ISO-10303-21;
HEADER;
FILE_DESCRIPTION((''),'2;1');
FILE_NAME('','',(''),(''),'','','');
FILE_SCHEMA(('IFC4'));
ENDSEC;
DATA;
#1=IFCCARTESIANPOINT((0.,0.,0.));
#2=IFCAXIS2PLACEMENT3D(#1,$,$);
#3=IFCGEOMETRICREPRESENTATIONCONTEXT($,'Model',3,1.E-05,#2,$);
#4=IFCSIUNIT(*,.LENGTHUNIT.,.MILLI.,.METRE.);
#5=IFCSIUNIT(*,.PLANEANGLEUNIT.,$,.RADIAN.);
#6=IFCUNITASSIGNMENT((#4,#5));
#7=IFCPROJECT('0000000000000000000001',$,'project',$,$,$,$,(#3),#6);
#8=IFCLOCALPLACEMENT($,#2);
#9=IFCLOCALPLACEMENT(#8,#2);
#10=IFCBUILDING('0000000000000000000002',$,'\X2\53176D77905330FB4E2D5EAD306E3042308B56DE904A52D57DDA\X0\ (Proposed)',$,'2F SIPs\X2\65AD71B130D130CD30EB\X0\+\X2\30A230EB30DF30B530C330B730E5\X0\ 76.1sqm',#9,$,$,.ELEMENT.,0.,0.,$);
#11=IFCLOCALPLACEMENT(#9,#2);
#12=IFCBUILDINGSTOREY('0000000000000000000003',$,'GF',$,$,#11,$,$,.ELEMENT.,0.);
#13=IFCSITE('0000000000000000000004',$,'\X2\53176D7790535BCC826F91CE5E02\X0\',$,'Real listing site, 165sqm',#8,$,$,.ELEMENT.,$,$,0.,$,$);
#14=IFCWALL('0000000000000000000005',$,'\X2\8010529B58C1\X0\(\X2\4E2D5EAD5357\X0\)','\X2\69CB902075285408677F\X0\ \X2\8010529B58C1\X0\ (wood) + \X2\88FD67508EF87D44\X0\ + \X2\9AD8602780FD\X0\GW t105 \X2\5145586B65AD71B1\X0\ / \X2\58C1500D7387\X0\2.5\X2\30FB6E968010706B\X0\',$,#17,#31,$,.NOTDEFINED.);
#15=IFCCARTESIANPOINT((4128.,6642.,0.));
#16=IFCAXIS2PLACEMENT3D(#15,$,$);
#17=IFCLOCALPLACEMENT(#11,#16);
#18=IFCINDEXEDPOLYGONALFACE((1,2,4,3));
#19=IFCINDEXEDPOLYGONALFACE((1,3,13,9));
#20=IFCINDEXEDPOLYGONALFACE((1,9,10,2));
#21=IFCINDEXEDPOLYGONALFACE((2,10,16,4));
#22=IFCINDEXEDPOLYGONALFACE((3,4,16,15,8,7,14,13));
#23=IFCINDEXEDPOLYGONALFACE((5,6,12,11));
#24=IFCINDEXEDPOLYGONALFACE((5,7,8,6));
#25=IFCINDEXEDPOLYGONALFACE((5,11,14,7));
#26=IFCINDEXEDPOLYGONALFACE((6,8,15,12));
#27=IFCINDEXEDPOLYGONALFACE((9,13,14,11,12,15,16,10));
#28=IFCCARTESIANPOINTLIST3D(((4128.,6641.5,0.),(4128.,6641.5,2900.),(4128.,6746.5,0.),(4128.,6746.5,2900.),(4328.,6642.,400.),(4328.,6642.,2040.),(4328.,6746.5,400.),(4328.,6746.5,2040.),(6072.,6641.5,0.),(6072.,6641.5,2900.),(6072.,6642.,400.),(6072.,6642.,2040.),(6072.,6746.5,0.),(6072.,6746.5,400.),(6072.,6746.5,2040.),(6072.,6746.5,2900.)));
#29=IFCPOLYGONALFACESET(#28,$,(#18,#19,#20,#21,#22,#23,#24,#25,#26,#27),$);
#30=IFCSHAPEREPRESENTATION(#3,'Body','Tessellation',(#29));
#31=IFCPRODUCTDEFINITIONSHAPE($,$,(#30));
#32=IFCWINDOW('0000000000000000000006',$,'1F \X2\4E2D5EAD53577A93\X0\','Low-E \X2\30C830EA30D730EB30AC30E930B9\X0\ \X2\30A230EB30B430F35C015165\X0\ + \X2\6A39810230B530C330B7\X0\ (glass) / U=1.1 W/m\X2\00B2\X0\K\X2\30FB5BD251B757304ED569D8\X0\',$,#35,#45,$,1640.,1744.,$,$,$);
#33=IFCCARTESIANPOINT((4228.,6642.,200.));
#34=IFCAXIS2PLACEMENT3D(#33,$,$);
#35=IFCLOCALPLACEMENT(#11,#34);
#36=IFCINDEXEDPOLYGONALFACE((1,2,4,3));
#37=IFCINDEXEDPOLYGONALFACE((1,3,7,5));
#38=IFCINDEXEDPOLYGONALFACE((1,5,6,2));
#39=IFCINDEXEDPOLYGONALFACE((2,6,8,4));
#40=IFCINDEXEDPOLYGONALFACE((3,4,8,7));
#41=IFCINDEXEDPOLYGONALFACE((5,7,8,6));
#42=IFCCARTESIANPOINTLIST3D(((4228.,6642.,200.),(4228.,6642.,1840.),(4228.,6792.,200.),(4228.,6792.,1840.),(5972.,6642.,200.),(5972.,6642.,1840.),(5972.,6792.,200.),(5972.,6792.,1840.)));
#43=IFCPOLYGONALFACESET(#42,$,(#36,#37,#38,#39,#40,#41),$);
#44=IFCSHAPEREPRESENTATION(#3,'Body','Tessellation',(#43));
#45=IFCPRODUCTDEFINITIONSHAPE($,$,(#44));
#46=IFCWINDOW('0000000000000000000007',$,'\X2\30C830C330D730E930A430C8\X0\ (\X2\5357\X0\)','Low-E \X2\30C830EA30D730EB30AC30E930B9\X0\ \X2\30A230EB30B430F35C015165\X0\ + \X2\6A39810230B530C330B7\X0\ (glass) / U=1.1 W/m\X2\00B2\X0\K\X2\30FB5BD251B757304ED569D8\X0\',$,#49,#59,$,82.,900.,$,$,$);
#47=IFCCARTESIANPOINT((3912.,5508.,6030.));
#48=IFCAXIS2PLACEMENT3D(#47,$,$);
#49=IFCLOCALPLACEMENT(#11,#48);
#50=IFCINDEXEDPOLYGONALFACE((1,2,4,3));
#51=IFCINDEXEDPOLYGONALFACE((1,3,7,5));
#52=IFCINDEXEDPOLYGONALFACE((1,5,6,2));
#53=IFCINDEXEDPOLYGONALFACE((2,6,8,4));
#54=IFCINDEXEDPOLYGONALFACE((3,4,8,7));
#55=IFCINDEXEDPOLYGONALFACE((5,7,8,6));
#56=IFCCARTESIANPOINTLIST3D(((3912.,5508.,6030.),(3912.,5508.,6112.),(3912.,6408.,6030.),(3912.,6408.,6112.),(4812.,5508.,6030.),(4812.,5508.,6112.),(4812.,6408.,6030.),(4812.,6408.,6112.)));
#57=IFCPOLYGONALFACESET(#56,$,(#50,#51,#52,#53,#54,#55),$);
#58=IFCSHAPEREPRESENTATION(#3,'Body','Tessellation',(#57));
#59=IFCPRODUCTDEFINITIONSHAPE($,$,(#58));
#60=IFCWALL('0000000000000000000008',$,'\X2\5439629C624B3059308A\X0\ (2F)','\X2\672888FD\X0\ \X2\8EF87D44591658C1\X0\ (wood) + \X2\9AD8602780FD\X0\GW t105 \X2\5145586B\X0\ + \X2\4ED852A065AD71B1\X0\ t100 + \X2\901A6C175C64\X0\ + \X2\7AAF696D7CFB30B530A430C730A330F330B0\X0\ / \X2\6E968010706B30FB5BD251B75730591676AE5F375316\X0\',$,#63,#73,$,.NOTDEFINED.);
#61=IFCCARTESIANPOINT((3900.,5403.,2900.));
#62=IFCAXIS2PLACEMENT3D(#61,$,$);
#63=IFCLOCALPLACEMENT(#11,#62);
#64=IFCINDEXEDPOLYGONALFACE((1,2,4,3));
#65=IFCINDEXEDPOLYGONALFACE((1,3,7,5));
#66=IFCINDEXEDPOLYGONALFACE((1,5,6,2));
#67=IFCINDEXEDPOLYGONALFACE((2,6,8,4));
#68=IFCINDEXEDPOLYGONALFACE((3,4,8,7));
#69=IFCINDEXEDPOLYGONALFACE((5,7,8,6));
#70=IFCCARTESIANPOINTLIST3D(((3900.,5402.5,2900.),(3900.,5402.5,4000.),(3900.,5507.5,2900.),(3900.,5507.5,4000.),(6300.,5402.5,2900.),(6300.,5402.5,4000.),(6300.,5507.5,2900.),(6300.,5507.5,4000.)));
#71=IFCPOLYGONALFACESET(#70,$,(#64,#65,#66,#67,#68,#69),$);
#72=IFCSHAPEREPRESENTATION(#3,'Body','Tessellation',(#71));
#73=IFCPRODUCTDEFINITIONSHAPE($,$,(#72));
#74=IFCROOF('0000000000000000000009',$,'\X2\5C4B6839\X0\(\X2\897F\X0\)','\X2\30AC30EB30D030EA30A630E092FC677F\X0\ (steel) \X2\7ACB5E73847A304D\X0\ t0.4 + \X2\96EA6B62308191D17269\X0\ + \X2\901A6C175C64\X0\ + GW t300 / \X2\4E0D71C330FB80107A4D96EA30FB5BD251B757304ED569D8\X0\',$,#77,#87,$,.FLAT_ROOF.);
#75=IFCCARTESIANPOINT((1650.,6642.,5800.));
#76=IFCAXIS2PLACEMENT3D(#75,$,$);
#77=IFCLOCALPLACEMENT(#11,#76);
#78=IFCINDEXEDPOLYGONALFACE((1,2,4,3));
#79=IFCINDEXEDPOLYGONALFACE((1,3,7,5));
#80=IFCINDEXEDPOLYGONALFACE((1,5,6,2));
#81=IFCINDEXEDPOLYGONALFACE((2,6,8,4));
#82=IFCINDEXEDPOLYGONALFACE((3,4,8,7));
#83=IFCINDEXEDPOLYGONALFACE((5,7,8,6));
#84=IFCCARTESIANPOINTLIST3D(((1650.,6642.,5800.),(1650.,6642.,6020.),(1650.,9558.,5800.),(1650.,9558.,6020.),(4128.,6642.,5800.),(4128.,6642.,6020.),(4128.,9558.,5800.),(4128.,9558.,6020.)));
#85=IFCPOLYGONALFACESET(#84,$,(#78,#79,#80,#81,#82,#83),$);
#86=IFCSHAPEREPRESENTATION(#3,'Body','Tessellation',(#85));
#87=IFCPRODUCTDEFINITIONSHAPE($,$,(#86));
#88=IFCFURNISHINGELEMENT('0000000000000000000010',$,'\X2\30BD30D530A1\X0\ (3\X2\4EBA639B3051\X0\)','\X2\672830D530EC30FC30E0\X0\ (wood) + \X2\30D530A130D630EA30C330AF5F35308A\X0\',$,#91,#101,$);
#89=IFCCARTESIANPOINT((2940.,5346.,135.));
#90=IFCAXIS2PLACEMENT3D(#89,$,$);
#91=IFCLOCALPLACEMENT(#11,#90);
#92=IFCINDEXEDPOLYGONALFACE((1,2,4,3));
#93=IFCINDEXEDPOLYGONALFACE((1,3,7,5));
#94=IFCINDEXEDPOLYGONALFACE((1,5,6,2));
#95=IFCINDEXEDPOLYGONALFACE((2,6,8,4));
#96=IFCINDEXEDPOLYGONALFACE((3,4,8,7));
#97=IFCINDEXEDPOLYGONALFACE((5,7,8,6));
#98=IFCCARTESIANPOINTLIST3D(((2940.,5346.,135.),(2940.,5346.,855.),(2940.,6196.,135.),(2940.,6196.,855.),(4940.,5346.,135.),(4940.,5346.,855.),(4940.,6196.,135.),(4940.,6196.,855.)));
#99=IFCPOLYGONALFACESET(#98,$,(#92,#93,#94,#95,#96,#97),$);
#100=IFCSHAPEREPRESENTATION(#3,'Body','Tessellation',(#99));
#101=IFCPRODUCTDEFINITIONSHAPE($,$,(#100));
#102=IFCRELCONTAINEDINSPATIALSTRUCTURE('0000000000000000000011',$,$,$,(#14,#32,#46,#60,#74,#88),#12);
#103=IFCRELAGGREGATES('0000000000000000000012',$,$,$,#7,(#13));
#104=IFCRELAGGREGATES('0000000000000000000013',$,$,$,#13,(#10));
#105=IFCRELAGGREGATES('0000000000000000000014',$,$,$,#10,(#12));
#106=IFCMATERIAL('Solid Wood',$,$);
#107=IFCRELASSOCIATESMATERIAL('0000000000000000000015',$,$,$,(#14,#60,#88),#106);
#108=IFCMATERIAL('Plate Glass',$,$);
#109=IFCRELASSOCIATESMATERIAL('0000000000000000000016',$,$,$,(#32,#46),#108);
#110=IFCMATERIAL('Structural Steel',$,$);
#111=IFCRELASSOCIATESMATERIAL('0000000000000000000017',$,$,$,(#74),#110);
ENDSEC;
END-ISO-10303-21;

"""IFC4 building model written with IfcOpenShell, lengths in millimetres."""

from ifc_helpers import new_model, si_unit, frame, frame_2d, origin, place, context, project, spatial, rectangle, extrude, material, element, fill, save


model = new_model("IFC4")

# Units and contexts
model_context = context("Model", 3, precision=1e-05, world=origin())
ifc_project = project(units=[si_unit("LENGTHUNIT", "METRE", prefix="MILLI"), si_unit("PLANEANGLEUNIT", "RADIAN")], contexts=[model_context])

# Site, building, storey
site_placement = place(None, origin())
site = spatial("IfcSite", under=ifc_project, at=site_placement, Name="北海道富良野市", ObjectType="Real listing site, 165sqm", CompositionType="ELEMENT", RefElevation=0.0)
building_placement = place(site_placement, origin())
building = spatial("IfcBuilding", under=site, at=building_placement, Name="北海道・中庭のある回遊動線 (Proposed)", ObjectType="2F SIPs断熱パネル+アルミサッシュ 76.1sqm", CompositionType="ELEMENT", ElevationOfRefHeight=0.0, ElevationOfTerrain=0.0)
storey_placement = place(building_placement, origin())
storey = spatial("IfcBuildingStorey", under=building, at=storey_placement, Name="GF", CompositionType="ELEMENT", Elevation=0.0)

# Shared definitions
ifc_material_1 = material(Name="Solid Wood")

# Wall, opening, window
wall_1_placement = place(storey_placement, frame((4128.0, 6642.0, 0.0)))
wall_1 = element("IfcWall", 1, at=wall_1_placement, inside=storey, material=ifc_material_1, Name="耐力壁(中庭南)", Description="構造用合板 耐力壁 (wood) + 製材軸組 + 高性能GW t105 充填断熱 / 壁倍率2.5・準耐火", PredefinedType="NOTDEFINED", context=model_context, shape_type="SweptSolid", body=[
    extrude(rectangle(XDim=1944.0, YDim=105.0, at=frame_2d((972.0, 52.0))), frame((4128.0, 6642.0, 0.0)), (0.0, 0.0, 1.0), 2900.0),
])
opening_placement = place(storey_placement, frame((4228.0, 6642.0, 200.0)))
opening = element("IfcOpeningElement", 2, at=opening_placement, cuts=wall_1, PredefinedType="NOTDEFINED", context=model_context, shape_type="SweptSolid", body=[
    extrude(rectangle(XDim=1744.0, YDim=150.0, at=frame_2d((872.0, 75.0))), frame((4228.0, 6642.0, 200.0)), (0.0, 0.0, 1.0), 1640.0),
])
ifc_material_2 = material(Name="Plate Glass")
window_1_placement = place(storey_placement, frame((4228.0, 6642.0, 200.0)))
window_1 = element("IfcWindow", 3, at=window_1_placement, inside=storey, material=ifc_material_2, Name="1F 中庭南窓", Description="Low-E トリプルガラス アルゴン封入 + 樹脂サッシ (glass) / U=1.1 W/m²K・寒冷地仕様", OverallHeight=1640.0, OverallWidth=1744.0, context=model_context, shape_type="SweptSolid", body=[
    extrude(rectangle(XDim=1744.0, YDim=150.0, at=frame_2d((872.0, 75.0))), frame((4228.0, 6642.0, 200.0)), (0.0, 0.0, 1.0), 1640.0),
])
fill(opening, window_1)

# Window
window_2_placement = place(storey_placement, frame((3912.0, 5508.0, 6030.0)))
element("IfcWindow", 4, at=window_2_placement, inside=storey, material=ifc_material_2, Name="トップライト (南)", Description="Low-E トリプルガラス アルゴン封入 + 樹脂サッシ (glass) / U=1.1 W/m²K・寒冷地仕様", OverallHeight=82.0, OverallWidth=900.0, context=model_context, shape_type="SweptSolid", body=[
    extrude(rectangle(XDim=900.0, YDim=900.0, at=frame_2d((450.0, 450.0))), frame((3912.0, 5508.0, 6030.0)), (0.0, 0.0, 1.0), 82.0),
])

# Wall
wall_2_placement = place(storey_placement, frame((3900.0, 5403.0, 2900.0)))
element("IfcWall", 5, at=wall_2_placement, inside=storey, material=ifc_material_1, Name="吹抜手すり (2F)", Description="木製 軸組外壁 (wood) + 高性能GW t105 充填 + 付加断熱 t100 + 通気層 + 窯業系サイディング / 準耐火・寒冷地外皮強化", PredefinedType="NOTDEFINED", context=model_context, shape_type="SweptSolid", body=[
    extrude(rectangle(XDim=2400.0, YDim=105.0, at=frame_2d((1200.0, 52.0))), frame((3900.0, 5403.0, 2900.0)), (0.0, 0.0, 1.0), 1100.0),
])

# Roof
ifc_material_3 = material(Name="Structural Steel")
for number, where, name in (
    (6, (1650.0, 6642.0, 5800.0), "屋根(西)"),
):
    element("IfcRoof", number, at=place(storey_placement, frame(where)), inside=storey, material=ifc_material_3, Name=name, Description="ガルバリウム鋼板 (steel) 立平葺き t0.4 + 雪止め金物 + 通気層 + GW t300 / 不燃・耐積雪・寒冷地仕様", PredefinedType="FLAT_ROOF", context=model_context, shape_type="SweptSolid", body=[
        extrude(rectangle(XDim=2478.0, YDim=2916.0, at=frame_2d((1239.0, 1458.0))), frame((1650.0, 6642.0, 5800.0)), (0.0, 0.0, 1.0), 220.0),
    ])

# Furnishing element
furnishing_placement = place(storey_placement, frame((2940.0, 5346.0, 135.0)))
element("IfcFurnishingElement", 7, at=furnishing_placement, inside=storey, material=ifc_material_1, Name="ソファ (3人掛け)", Description="木フレーム (wood) + ファブリック張り", context=model_context, shape_type="SweptSolid", body=[
    extrude(rectangle(XDim=2000.0, YDim=850.0, at=frame_2d((1000.0, 425.0))), frame((2940.0, 5346.0, 135.0)), (0.0, 0.0, 1.0), 720.0),
])

save(model, "model.ifc")
